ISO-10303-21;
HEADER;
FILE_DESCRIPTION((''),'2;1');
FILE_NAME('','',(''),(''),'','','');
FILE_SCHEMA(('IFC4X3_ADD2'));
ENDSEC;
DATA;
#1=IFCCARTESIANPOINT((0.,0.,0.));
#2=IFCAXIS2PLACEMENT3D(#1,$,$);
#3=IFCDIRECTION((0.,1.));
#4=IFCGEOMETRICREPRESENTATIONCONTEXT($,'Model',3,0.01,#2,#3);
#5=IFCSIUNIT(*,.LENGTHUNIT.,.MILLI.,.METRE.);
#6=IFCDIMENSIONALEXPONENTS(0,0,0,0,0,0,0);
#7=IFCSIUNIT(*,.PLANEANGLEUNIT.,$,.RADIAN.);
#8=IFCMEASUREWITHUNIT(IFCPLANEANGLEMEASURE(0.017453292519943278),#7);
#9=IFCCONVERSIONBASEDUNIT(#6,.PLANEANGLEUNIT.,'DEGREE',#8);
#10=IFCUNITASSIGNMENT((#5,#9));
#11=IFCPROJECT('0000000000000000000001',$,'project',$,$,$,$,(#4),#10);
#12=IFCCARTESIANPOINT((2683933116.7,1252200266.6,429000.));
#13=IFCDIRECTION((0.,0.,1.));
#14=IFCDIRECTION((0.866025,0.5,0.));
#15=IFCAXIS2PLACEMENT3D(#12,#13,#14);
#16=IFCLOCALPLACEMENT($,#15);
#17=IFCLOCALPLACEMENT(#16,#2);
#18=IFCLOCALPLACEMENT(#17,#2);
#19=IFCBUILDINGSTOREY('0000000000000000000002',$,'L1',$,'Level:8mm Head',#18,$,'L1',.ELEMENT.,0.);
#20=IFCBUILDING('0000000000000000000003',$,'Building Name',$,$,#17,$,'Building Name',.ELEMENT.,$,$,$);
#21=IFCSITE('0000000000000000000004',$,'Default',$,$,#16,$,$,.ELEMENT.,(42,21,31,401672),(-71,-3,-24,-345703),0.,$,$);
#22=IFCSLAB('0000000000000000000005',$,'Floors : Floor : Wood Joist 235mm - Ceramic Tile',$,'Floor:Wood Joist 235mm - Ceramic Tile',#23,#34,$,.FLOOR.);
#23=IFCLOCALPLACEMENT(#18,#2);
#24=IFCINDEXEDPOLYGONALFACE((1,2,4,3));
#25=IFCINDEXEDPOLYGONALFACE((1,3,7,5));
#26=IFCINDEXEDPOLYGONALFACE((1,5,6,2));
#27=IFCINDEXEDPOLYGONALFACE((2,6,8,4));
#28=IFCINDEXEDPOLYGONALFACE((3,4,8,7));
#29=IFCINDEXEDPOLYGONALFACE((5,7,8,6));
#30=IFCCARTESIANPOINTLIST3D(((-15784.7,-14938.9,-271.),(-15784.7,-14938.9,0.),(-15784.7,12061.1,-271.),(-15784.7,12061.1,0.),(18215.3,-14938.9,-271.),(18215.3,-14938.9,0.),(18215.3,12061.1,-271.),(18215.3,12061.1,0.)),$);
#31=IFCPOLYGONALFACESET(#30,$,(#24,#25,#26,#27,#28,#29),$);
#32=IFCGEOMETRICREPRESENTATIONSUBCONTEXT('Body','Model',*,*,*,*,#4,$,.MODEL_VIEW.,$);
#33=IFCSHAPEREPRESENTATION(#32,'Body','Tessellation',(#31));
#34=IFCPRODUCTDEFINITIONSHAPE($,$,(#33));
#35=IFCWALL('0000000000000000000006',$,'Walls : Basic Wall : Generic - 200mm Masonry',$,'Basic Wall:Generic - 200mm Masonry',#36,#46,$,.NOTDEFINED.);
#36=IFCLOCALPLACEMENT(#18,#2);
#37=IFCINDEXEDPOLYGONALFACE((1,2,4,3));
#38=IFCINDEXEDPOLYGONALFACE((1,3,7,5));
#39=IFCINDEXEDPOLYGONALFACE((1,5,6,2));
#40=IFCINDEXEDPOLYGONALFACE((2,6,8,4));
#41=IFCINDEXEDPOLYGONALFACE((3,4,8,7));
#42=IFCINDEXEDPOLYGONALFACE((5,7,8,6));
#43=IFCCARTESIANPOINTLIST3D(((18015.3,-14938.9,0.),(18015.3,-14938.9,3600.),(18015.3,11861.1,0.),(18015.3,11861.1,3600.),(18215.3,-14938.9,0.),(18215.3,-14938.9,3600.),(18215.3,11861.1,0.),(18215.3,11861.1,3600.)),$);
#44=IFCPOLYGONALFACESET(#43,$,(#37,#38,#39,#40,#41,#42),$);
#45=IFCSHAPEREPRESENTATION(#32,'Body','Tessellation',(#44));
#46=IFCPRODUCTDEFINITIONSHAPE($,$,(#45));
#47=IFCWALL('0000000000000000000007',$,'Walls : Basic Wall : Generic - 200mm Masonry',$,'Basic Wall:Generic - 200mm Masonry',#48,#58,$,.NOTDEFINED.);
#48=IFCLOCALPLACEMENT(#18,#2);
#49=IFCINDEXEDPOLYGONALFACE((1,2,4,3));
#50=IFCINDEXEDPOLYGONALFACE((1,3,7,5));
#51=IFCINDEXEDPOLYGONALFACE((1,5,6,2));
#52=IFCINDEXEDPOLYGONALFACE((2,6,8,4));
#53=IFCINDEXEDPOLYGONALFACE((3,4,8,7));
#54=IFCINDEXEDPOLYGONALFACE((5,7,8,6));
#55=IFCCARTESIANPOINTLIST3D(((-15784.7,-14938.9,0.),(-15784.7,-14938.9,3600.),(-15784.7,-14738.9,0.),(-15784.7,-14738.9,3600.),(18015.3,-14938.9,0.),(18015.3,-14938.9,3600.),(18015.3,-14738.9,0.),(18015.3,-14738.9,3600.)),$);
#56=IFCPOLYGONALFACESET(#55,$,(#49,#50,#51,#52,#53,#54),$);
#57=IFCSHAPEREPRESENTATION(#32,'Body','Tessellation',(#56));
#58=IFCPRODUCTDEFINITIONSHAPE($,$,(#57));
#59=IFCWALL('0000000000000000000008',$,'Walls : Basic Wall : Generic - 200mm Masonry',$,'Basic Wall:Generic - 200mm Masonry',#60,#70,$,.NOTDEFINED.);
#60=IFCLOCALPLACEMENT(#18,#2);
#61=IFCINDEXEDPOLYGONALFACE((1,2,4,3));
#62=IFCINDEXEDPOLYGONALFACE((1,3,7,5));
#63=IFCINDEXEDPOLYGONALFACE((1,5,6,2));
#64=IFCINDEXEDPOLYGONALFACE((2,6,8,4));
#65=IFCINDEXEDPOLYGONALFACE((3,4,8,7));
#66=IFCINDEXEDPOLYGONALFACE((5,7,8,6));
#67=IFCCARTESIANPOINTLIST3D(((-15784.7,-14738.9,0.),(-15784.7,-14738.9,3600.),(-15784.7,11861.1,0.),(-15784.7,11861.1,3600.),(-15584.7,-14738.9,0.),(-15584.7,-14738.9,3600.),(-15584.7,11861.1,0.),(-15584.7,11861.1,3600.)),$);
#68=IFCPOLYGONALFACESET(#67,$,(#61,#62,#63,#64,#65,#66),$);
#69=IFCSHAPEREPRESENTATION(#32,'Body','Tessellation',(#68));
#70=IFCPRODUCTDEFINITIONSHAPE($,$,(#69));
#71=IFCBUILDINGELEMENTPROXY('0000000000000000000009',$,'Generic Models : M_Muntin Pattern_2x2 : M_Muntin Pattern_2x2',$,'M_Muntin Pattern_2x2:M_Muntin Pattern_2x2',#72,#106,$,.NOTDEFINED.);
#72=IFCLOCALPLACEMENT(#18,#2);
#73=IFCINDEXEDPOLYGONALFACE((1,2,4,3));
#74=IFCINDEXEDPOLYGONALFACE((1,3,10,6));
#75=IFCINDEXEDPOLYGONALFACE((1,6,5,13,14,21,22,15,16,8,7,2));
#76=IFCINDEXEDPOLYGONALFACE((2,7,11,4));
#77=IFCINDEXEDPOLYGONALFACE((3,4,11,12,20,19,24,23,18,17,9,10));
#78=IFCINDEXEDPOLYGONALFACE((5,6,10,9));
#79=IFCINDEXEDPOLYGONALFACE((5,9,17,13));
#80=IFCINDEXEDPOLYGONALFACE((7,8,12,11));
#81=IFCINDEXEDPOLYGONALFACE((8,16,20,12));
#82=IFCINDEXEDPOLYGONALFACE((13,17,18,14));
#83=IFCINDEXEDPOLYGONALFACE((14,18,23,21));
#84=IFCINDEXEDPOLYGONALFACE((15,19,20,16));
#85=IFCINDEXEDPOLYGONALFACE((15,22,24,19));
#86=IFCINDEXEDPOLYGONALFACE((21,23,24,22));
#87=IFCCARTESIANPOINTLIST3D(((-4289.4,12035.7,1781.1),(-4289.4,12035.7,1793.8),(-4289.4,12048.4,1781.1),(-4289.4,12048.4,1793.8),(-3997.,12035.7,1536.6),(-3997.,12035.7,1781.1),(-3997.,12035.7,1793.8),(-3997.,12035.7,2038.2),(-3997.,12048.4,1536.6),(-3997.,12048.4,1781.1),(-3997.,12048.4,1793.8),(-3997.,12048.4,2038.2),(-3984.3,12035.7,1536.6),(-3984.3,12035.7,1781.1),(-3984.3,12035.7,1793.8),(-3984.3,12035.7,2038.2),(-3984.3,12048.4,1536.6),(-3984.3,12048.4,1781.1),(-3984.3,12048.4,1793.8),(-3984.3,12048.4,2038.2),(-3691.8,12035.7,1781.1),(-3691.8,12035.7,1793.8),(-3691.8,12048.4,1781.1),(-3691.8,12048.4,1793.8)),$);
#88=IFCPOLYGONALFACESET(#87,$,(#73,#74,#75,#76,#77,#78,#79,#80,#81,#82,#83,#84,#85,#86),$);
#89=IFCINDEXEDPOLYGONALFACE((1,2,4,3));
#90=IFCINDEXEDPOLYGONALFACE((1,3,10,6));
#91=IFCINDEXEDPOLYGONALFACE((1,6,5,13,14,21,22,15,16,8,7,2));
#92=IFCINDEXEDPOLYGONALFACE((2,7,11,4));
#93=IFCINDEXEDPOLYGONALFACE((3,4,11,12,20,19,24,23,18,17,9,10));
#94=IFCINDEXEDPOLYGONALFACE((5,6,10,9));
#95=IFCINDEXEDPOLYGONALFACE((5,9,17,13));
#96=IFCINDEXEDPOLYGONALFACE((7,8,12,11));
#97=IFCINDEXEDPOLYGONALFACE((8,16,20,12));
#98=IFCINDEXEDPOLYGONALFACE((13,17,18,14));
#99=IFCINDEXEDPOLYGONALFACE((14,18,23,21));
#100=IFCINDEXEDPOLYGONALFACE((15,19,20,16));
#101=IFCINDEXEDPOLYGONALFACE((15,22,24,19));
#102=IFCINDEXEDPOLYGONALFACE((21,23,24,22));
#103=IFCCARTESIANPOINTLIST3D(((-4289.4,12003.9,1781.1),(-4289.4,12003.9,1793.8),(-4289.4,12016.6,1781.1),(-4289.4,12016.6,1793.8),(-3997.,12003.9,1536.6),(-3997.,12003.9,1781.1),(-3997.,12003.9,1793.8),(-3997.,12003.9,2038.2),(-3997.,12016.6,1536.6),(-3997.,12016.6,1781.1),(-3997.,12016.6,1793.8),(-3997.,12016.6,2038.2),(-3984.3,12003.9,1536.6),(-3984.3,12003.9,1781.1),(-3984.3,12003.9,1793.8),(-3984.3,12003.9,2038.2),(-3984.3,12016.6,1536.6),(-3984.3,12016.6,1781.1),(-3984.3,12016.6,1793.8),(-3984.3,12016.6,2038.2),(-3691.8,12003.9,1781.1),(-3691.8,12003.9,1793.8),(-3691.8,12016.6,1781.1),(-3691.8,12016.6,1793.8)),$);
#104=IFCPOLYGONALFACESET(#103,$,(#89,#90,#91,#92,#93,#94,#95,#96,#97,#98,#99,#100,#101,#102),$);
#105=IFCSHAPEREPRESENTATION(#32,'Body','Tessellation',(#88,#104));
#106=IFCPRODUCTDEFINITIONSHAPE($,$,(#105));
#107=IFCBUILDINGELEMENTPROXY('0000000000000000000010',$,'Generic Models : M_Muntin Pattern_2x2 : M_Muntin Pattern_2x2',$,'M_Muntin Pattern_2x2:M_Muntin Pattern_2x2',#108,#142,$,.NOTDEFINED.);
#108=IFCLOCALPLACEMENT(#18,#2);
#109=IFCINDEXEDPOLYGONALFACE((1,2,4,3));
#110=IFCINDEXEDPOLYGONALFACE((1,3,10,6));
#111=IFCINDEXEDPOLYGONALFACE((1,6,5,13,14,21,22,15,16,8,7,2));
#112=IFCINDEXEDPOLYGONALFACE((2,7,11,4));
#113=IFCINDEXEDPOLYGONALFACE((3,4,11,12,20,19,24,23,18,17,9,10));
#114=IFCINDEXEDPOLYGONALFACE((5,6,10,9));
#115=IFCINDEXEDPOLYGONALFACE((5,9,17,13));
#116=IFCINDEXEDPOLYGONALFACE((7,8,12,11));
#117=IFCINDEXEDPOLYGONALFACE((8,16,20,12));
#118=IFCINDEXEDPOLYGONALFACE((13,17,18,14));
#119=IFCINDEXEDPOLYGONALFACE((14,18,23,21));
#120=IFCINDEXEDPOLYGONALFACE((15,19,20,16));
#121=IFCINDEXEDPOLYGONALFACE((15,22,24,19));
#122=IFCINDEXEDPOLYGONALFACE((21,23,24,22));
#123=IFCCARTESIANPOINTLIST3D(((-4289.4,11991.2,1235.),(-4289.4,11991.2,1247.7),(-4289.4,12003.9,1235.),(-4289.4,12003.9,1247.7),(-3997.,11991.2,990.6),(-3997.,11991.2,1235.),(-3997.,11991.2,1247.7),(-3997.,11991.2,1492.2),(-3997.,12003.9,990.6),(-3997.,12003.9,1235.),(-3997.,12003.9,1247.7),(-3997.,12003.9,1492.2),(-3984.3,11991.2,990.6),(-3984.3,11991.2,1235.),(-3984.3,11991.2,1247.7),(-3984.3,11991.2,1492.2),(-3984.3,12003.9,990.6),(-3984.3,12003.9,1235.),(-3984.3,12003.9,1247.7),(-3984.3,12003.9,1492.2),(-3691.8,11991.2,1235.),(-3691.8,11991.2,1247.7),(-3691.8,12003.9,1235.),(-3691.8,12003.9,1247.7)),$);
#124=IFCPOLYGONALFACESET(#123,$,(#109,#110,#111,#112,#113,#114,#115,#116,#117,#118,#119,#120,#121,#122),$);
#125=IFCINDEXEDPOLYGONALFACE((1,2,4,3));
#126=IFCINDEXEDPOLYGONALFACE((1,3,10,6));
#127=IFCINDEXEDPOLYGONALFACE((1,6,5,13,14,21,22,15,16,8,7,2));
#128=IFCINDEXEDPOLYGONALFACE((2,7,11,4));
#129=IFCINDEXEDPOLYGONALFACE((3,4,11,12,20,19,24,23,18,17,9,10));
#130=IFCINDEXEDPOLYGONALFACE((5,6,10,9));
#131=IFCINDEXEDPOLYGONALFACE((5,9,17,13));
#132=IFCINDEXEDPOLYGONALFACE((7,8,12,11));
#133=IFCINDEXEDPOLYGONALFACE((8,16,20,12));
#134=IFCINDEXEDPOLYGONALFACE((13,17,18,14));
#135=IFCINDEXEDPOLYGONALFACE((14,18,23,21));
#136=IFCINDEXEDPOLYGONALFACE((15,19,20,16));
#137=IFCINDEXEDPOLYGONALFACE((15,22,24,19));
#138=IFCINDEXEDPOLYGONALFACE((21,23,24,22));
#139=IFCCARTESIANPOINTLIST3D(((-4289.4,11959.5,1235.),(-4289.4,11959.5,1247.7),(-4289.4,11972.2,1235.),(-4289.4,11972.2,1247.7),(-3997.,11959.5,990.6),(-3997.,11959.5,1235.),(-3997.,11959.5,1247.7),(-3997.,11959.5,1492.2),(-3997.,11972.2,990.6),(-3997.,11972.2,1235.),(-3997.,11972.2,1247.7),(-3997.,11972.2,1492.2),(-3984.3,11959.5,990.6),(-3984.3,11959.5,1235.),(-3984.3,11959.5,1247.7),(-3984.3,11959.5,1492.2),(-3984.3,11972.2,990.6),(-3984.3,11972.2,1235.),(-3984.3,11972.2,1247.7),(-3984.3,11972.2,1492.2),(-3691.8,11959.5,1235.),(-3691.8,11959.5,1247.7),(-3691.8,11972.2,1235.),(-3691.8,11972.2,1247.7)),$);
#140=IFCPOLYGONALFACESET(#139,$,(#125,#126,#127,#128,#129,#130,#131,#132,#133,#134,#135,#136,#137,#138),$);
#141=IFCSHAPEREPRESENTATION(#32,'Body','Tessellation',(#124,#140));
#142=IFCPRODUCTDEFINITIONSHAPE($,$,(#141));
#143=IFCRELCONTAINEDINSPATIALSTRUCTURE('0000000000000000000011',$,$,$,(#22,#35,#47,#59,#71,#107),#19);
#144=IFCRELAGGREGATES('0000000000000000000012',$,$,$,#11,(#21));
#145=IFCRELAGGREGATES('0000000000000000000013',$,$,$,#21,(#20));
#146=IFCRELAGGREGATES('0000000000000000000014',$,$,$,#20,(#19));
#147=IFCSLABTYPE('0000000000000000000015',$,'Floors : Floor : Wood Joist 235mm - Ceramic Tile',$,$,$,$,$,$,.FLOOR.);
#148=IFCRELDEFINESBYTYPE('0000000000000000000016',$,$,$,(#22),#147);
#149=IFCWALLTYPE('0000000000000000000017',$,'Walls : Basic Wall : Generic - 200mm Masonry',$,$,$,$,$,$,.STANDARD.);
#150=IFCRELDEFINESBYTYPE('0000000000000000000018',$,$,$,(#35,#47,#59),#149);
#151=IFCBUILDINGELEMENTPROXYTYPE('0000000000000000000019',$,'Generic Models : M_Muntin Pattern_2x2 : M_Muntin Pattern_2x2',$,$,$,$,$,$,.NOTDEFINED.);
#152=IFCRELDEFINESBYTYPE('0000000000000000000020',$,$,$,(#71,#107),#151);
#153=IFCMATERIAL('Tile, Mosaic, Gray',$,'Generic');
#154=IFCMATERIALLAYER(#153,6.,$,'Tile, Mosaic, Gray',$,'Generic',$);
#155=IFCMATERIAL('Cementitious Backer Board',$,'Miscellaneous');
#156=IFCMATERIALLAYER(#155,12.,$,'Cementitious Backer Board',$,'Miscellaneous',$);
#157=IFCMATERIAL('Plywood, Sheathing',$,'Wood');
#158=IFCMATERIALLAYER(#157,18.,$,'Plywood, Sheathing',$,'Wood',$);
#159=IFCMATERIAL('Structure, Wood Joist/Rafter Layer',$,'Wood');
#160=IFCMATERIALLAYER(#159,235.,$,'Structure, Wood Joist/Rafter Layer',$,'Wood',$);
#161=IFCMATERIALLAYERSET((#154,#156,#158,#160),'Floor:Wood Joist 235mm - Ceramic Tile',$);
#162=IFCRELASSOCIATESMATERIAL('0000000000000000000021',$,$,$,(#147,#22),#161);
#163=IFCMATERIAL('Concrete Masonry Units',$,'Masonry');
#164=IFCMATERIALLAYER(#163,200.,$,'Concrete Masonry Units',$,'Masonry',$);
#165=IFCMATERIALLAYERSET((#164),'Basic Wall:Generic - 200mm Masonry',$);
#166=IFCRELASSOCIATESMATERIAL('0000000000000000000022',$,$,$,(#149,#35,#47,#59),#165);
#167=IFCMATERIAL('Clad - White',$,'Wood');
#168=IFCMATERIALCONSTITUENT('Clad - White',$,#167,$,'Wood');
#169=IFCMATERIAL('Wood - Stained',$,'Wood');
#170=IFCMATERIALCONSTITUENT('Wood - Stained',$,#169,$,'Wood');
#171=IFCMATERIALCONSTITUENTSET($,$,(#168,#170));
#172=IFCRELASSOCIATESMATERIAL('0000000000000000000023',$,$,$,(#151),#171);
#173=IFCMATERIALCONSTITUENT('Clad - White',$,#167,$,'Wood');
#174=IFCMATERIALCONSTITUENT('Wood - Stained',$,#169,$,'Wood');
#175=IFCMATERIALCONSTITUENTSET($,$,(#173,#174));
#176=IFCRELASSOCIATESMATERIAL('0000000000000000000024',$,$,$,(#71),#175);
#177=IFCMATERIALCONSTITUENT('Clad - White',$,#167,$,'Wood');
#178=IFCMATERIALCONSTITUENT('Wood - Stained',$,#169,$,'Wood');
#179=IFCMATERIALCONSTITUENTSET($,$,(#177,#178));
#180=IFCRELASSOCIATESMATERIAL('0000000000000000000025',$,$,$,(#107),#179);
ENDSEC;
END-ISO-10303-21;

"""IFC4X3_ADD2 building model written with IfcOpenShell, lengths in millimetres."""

from ifc_helpers import new_model, entity, si_unit, converted_unit, direction, frame, frame_2d, origin, origin_2d_with_axis, place, context, subcontext, project, spatial, polyline, rectangle, outline, extrude, source, transform, mapped, material, layer, layer_set, layer_usage, constituent, constituent_set, type_object, type_shapes, element, save


model = new_model("IFC4X3_ADD2")

# Units and contexts
model_context = context("Model", 3, precision=0.01, world=origin(), true_north=direction((0.0, 1.0)))
body_context = subcontext(model_context, "Body", "Model", "MODEL_VIEW")
ifc_project = project(units=[si_unit("LENGTHUNIT", "METRE", prefix="MILLI"), converted_unit("PLANEANGLEUNIT", "DEGREE", entity("IfcPlaneAngleMeasure", 0.017453292519943278), si_unit("PLANEANGLEUNIT", "RADIAN"), dimensions=[0, 0, 0, 0, 0, 0, 0])], contexts=[model_context])

# Site, building, storey
site_placement = place(None, frame((2683933116.7, 1252200266.6, 429000.0), z_axis=(0.0, 0.0, 1.0), x_axis=(0.866025, 0.5, 0.0)))
site = spatial("IfcSite", under=ifc_project, at=site_placement, Name="Default", CompositionType="ELEMENT", RefLatitude=(42, 21, 31, 401672), RefLongitude=(-71, -3, -24, -345703), RefElevation=0.0)
building_placement = place(site_placement, origin())
building = spatial("IfcBuilding", under=site, at=building_placement, Name="Building Name", LongName="Building Name", CompositionType="ELEMENT")
storey_placement = place(building_placement, origin())
storey = spatial("IfcBuildingStorey", under=building, at=storey_placement, Name="L1", ObjectType="Level:8mm Head", LongName="L1", CompositionType="ELEMENT", Elevation=0.0)

# Slab
ifc_material_1 = material(Name="Tile, Mosaic, Gray", Category="Generic")
ifc_layer_1 = layer(ifc_material_1, 6.0, Name="Tile, Mosaic, Gray", Category="Generic")
ifc_material_2 = material(Name="Cementitious Backer Board", Category="Miscellaneous")
ifc_layer_2 = layer(ifc_material_2, 12.0, Name="Cementitious Backer Board", Category="Miscellaneous")
ifc_material_3 = material(Name="Plywood, Sheathing", Category="Wood")
ifc_layer_3 = layer(ifc_material_3, 18.0, Name="Plywood, Sheathing", Category="Wood")
ifc_material_4 = material(Name="Structure, Wood Joist/Rafter Layer", Category="Wood")
ifc_layer_4 = layer(ifc_material_4, 235.0, Name="Structure, Wood Joist/Rafter Layer", Category="Wood")
ifc_layer_set_1 = layer_set([ifc_layer_1, ifc_layer_2, ifc_layer_3, ifc_layer_4], Name="Floor:Wood Joist 235mm - Ceramic Tile")
ifc_layer_usage = layer_usage(ifc_layer_set_1, "AXIS3", "POSITIVE", 0.0)
slab_type = type_object("IfcSlabType", Name="Floors : Floor : Wood Joist 235mm - Ceramic Tile", PredefinedType="FLOOR", material=ifc_layer_set_1)
slab_placement = place(storey_placement, origin())
element("IfcSlab", 1, at=slab_placement, inside=storey, type_object=slab_type, material=ifc_layer_usage, Name="Floors : Floor : Wood Joist 235mm - Ceramic Tile", ObjectType="Floor:Wood Joist 235mm - Ceramic Tile", PredefinedType="FLOOR", context=body_context, shape_type="SweptSolid", body=[
    extrude(rectangle(XDim=27000.0, YDim=34000.0, at=origin_2d_with_axis()), frame((1215.3, -1438.9, 0.0), z_axis=(0.0, 0.0, -1.0), x_axis=(0.0, 1.0, 0.0)), (0.0, 0.0, 1.0), 271.0),
])

# Shared definitions
ifc_material_5 = material(Name="Concrete Masonry Units", Category="Masonry")
ifc_layer_5 = layer(ifc_material_5, 200.0, Name="Concrete Masonry Units", Category="Masonry")
ifc_layer_set_2 = layer_set([ifc_layer_5], Name="Basic Wall:Generic - 200mm Masonry")
wall_type = type_object("IfcWallType", Name="Walls : Basic Wall : Generic - 200mm Masonry", PredefinedType="STANDARD", material=ifc_layer_set_2)
ifc_material_6 = material(Name="Wood - Stained", Category="Wood")

# Walls
wall_1_placement = place(storey_placement, frame((18115.3, 11861.1, 0.0), z_axis=(0.0, 0.0, 1.0), x_axis=(0.0, -1.0, 0.0)))
element("IfcWall", 2, at=wall_1_placement, inside=storey, type_object=wall_type, material=ifc_layer_set_2, Name="Walls : Basic Wall : Generic - 200mm Masonry", ObjectType="Basic Wall:Generic - 200mm Masonry", PredefinedType="NOTDEFINED", context=body_context, shape_type="SweptSolid", body=[
    extrude(rectangle(XDim=26800.0, YDim=200.0, at=frame_2d((13400.0, 0.0), x_axis=(-1.0, 0.0))), origin(), (0.0, 0.0, 1.0), 3600.0),
])
wall_2_placement = place(storey_placement, frame((18015.3, -14838.9, 0.0), z_axis=(0.0, 0.0, 1.0), x_axis=(-1.0, 0.0, 0.0)))
element("IfcWall", 3, at=wall_2_placement, inside=storey, type_object=wall_type, material=ifc_layer_set_2, Name="Walls : Basic Wall : Generic - 200mm Masonry", ObjectType="Basic Wall:Generic - 200mm Masonry", PredefinedType="NOTDEFINED", context=body_context, shape_type="SweptSolid", body=[
    extrude(rectangle(XDim=33800.0, YDim=200.0, at=frame_2d((16900.0, 0.0), x_axis=(-1.0, 0.0))), origin(), (0.0, 0.0, 1.0), 3600.0),
])
wall_3_placement = place(storey_placement, frame((-15684.7, -14738.9, 0.0), z_axis=(0.0, 0.0, 1.0), x_axis=(0.0, 1.0, 0.0)))
element("IfcWall", 4, at=wall_3_placement, inside=storey, type_object=wall_type, material=ifc_layer_set_2, Name="Walls : Basic Wall : Generic - 200mm Masonry", ObjectType="Basic Wall:Generic - 200mm Masonry", PredefinedType="NOTDEFINED", context=body_context, shape_type="SweptSolid", body=[
    extrude(rectangle(XDim=26600.0, YDim=200.0, at=frame_2d((13300.0, 0.0), x_axis=(-1.0, 0.0))), origin(), (0.0, 0.0, 1.0), 3600.0),
])

# Building element proxies
ifc_material_7 = material(Name="Clad - White", Category="Wood")
ifc_constituent_1 = constituent(ifc_material_7, Name="Clad - White", Category="Wood")
ifc_constituent_2 = constituent(ifc_material_6, Name="Wood - Stained", Category="Wood")
ifc_constituent_set_1 = constituent_set(constituents=[ifc_constituent_1, ifc_constituent_2])
ifc_constituent_3 = constituent(ifc_material_7, Name="Clad - White", Category="Wood")
ifc_constituent_4 = constituent(ifc_material_6, Name="Wood - Stained", Category="Wood")
ifc_constituent_set_2 = constituent_set(constituents=[ifc_constituent_3, ifc_constituent_4])
building_element_proxy_type_1 = type_object("IfcBuildingElementProxyType", Name="Generic Models : M_Muntin Pattern_2x2 : M_Muntin Pattern_2x2", PredefinedType="NOTDEFINED", material=ifc_constituent_set_2)
shared_shape_1 = source(origin(), body_context, "Body", "SweptSolid", [
    extrude(outline(polyline([(6.4, -6.4), (250.8, -6.4), (250.8, 6.3), (6.4, 6.3), (6.4, 298.8), (-6.3, 298.8), (-6.3, 6.3), (-250.8, 6.3), (-250.8, -6.4), (-6.3, -6.4), (-6.3, -298.8), (6.4, -298.8), (6.4, -6.4)])), frame((0.0, 9.5, 250.8), z_axis=(0.0, 1.0, 0.0), x_axis=(0.0, 0.0, 1.0)), (0.0, 0.0, 1.0), 12.7),
    extrude(outline(polyline([(6.4, -6.4), (250.8, -6.4), (250.8, 6.3), (6.4, 6.3), (6.4, 298.8), (-6.3, 298.8), (-6.3, 6.3), (-250.8, 6.3), (-250.8, -6.4), (-6.3, -6.4), (-6.3, -298.8), (6.4, -298.8), (6.4, -6.4)])), frame((0.0, -22.2, 250.8), z_axis=(0.0, 1.0, 0.0), x_axis=(0.0, 0.0, 1.0)), (0.0, 0.0, 1.0), 12.7),
])
type_shapes(building_element_proxy_type_1, [shared_shape_1])
proxy_1_placement = place(storey_placement, frame((-3990.6, 12026.1, 1536.6)))
element("IfcBuildingElementProxy", 5, at=proxy_1_placement, inside=storey, type_object=building_element_proxy_type_1, material=ifc_constituent_set_1, Name="Generic Models : M_Muntin Pattern_2x2 : M_Muntin Pattern_2x2", ObjectType="M_Muntin Pattern_2x2:M_Muntin Pattern_2x2", PredefinedType="NOTDEFINED", context=body_context, shape_type="MappedRepresentation", body=[
    mapped(shared_shape_1, transform((0.0, 0.0, 0.0), scale=1.0)),
])
ifc_constituent_5 = constituent(ifc_material_7, Name="Clad - White", Category="Wood")
ifc_constituent_6 = constituent(ifc_material_6, Name="Wood - Stained", Category="Wood")
ifc_constituent_set_3 = constituent_set(constituents=[ifc_constituent_5, ifc_constituent_6])
proxy_2_placement = place(storey_placement, frame((-3990.6, 11981.7, 990.6)))
element("IfcBuildingElementProxy", 6, at=proxy_2_placement, inside=storey, type_object=building_element_proxy_type_1, material=ifc_constituent_set_3, Name="Generic Models : M_Muntin Pattern_2x2 : M_Muntin Pattern_2x2", ObjectType="M_Muntin Pattern_2x2:M_Muntin Pattern_2x2", PredefinedType="NOTDEFINED", context=body_context, shape_type="MappedRepresentation", body=[
    mapped(shared_shape_1, transform((0.0, 0.0, 0.0), scale=1.0)),
])

save(model, "model.ifc")
